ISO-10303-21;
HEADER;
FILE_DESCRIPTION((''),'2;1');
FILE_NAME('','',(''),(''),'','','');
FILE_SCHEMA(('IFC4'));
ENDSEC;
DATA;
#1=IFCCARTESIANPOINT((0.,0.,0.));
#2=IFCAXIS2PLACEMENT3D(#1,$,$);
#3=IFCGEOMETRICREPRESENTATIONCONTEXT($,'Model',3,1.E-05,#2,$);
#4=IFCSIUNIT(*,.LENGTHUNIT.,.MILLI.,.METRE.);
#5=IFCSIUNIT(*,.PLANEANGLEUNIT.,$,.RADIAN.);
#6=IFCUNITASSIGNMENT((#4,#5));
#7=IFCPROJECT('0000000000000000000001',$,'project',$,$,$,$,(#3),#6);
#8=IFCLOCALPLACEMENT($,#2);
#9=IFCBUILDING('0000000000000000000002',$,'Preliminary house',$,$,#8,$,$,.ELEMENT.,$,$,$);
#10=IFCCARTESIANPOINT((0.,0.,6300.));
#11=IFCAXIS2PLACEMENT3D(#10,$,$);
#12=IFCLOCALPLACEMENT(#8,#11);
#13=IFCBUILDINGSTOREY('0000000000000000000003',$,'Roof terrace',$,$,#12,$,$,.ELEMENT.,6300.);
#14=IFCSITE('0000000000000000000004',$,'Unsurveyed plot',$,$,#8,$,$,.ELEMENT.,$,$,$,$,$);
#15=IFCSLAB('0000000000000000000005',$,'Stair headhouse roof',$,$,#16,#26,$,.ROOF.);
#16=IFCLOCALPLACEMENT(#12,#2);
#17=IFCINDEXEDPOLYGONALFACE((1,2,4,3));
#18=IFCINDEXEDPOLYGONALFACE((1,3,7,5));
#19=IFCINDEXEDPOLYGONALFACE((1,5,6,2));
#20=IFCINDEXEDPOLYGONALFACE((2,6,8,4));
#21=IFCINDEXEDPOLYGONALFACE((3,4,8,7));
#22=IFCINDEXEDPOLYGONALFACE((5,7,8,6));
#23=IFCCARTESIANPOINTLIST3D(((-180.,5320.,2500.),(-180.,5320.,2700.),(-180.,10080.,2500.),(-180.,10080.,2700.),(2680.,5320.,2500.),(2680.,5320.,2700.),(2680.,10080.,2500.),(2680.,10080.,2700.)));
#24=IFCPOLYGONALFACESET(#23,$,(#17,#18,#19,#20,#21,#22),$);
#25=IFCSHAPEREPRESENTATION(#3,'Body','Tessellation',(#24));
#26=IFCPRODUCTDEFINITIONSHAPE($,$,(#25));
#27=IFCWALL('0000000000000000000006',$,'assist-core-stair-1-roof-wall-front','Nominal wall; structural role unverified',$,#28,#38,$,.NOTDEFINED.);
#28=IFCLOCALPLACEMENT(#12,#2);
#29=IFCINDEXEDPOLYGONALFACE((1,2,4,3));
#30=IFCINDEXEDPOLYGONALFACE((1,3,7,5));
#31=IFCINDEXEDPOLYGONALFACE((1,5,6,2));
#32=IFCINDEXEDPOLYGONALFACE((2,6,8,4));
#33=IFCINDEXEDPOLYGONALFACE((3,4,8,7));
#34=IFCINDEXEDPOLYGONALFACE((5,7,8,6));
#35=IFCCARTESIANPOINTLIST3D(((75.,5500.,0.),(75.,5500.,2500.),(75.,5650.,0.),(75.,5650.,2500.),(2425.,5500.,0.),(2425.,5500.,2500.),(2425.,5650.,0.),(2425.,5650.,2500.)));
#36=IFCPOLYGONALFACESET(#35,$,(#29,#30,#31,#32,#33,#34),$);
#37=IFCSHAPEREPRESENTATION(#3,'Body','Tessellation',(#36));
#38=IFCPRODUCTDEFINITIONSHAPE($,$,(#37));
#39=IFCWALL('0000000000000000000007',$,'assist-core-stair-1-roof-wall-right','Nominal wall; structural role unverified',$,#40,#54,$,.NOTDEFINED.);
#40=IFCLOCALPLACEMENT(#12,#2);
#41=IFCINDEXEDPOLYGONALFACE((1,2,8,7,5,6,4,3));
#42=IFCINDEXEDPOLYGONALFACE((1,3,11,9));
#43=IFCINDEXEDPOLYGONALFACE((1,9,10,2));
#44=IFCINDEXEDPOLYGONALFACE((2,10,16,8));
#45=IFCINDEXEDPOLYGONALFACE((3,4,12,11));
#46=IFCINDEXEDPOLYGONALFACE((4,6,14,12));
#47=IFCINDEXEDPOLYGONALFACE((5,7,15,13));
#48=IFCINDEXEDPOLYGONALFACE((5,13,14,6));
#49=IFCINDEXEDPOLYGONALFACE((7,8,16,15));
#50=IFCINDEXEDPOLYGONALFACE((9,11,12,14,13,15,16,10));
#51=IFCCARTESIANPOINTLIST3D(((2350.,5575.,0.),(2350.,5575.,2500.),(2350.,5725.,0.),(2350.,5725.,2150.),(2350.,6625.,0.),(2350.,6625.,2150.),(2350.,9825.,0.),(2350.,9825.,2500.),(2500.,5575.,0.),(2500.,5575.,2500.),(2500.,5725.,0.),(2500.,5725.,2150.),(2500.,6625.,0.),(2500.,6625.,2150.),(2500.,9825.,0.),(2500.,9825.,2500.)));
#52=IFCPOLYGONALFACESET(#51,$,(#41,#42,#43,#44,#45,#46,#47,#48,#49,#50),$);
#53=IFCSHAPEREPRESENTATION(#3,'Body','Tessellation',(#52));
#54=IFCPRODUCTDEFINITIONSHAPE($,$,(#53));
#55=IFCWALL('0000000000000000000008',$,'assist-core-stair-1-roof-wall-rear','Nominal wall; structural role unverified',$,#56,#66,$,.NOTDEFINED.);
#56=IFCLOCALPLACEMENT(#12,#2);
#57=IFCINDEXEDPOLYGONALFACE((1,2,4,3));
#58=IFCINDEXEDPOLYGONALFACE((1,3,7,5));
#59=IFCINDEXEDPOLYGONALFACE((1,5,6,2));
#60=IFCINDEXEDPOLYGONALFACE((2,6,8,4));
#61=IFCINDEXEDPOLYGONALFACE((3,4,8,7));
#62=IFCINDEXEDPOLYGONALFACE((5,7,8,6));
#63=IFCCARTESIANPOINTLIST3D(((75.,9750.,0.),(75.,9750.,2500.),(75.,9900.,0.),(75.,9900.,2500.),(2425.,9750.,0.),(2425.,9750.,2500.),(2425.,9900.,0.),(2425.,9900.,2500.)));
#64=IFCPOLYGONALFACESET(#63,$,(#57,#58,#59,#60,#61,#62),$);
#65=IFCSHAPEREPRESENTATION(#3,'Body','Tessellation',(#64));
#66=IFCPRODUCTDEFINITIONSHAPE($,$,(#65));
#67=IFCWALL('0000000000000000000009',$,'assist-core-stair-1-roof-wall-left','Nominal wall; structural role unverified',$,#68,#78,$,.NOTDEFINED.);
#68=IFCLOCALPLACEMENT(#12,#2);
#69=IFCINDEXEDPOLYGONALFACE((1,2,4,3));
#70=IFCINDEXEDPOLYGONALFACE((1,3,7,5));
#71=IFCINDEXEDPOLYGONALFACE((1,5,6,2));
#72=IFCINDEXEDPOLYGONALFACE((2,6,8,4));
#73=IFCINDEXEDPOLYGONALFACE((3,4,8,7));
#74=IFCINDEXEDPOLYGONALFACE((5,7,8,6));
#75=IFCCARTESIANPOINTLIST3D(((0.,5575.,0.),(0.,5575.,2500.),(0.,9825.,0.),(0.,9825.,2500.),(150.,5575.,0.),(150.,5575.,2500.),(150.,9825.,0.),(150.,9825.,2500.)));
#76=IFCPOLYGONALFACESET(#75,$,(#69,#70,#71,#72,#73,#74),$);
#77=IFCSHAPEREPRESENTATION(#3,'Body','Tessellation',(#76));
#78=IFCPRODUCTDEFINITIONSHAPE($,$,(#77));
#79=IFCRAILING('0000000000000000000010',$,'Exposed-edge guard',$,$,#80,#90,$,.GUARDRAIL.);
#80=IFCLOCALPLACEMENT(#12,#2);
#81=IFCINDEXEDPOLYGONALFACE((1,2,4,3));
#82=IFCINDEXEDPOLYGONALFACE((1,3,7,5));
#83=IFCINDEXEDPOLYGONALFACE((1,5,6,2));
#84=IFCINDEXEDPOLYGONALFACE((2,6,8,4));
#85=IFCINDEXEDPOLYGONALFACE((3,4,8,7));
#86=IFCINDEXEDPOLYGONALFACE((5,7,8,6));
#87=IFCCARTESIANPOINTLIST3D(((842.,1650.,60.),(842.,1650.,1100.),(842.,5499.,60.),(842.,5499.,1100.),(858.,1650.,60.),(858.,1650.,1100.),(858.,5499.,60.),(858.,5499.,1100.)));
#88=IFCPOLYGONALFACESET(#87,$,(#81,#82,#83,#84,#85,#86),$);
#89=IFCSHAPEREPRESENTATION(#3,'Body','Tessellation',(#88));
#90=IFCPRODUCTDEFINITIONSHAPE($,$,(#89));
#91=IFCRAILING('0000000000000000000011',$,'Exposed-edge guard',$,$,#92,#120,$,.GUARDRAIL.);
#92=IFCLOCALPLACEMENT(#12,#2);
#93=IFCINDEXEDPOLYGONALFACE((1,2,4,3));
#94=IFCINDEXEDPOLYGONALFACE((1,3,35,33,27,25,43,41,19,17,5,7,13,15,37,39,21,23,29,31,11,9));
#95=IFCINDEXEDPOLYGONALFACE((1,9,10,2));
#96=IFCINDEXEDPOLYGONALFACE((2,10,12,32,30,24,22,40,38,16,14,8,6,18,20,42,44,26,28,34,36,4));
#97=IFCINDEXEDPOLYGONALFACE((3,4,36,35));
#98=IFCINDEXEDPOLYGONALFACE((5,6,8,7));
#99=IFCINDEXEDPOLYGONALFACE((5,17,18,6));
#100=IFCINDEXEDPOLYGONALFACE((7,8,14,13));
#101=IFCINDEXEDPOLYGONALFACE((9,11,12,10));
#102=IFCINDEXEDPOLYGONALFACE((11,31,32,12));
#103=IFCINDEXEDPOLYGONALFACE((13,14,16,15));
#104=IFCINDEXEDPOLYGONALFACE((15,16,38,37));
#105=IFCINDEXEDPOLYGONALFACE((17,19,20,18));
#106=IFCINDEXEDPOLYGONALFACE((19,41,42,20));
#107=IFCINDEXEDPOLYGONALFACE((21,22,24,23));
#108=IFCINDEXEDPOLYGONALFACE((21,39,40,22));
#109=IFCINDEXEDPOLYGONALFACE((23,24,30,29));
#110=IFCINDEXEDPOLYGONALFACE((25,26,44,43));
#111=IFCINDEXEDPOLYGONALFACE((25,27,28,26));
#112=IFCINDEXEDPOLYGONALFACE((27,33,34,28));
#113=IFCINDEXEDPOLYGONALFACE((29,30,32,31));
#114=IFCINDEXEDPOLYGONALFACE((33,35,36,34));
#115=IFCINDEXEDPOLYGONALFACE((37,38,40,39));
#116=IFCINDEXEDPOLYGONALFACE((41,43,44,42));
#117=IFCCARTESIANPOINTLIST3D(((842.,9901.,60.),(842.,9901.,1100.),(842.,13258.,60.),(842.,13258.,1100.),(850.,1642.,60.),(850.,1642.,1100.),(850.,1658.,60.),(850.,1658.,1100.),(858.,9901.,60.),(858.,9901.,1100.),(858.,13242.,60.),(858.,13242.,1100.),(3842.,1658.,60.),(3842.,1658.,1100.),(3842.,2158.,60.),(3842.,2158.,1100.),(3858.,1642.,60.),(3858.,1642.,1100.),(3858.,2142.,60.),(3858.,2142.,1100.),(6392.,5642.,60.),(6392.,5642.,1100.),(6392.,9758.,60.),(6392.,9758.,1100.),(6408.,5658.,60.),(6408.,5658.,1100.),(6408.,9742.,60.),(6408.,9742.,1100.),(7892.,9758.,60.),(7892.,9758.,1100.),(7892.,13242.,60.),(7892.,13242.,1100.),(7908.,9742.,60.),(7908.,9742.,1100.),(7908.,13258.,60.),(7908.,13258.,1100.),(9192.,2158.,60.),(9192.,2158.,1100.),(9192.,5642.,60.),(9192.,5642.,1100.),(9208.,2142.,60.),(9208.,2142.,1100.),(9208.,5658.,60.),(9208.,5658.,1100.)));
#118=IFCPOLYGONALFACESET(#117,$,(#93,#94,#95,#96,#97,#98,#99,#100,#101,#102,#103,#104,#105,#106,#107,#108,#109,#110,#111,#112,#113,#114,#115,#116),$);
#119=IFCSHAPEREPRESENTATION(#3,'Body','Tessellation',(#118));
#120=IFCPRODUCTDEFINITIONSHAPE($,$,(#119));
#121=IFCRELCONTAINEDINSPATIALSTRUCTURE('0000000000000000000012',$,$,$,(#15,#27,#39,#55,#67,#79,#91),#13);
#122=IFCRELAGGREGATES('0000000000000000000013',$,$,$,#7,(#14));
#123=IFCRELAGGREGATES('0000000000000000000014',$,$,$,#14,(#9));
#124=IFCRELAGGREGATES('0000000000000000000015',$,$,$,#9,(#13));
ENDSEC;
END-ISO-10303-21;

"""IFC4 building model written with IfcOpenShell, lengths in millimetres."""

from ifc_helpers import new_model, si_unit, frame, origin, place, context, project, spatial, polyline, outline, extrude, element, save


model = new_model("IFC4")

# Units and contexts
model_context = context("Model", 3, precision=1e-05, world=origin())
ifc_project = project(units=[si_unit("LENGTHUNIT", "METRE", prefix="MILLI"), si_unit("PLANEANGLEUNIT", "RADIAN")], contexts=[model_context])

# Site, building, storey
placement_1 = place(None, origin())
site = spatial("IfcSite", under=ifc_project, at=placement_1, Name="Unsurveyed plot", CompositionType="ELEMENT")
building = spatial("IfcBuilding", under=site, at=placement_1, Name="Preliminary house", CompositionType="ELEMENT")
placement_2 = place(placement_1, frame((0.0, 0.0, 6300.0)))
storey = spatial("IfcBuildingStorey", under=building, at=placement_2, Name="Roof terrace", CompositionType="ELEMENT", Elevation=6300.0)

# Slab
element("IfcSlab", 1, at=placement_2, inside=storey, Name="Stair headhouse roof", PredefinedType="ROOF", context=model_context, shape_type="SweptSolid", body=[
    extrude(outline(polyline([(2680.0, 5320.0), (-180.0, 5320.0), (-180.0, 10080.0), (2680.0, 10080.0), (2680.0, 5320.0)])), frame((0.0, 0.0, 2500.0)), (0.0, 0.0, 1.0), 200.0),
])

# Wall
element("IfcWall", 2, at=placement_2, inside=storey, Name="assist-core-stair-1-roof-wall-front", Description="Nominal wall; structural role unverified", PredefinedType="NOTDEFINED", context=model_context, shape_type="SweptSolid", body=[
    extrude(outline(polyline([(2425.0, 5650.0), (2425.0, 5500.0), (75.0, 5500.0), (75.0, 5650.0), (2425.0, 5650.0)])), origin(), (0.0, 0.0, 1.0), 2500.0),
])

# Wall, opening
wall_1 = element("IfcWall", 3, at=placement_2, inside=storey, Name="assist-core-stair-1-roof-wall-right", Description="Nominal wall; structural role unverified", PredefinedType="NOTDEFINED", context=model_context, shape_type="SweptSolid", body=[
    extrude(outline(polyline([(2350.0, 9825.0), (2500.0, 9825.0), (2500.0, 5575.0), (2350.0, 5575.0), (2350.0, 9825.0)])), origin(), (0.0, 0.0, 1.0), 2500.0),
])
element("IfcOpeningElement", 4, at=placement_2, cuts=wall_1, PredefinedType="OPENING", context=model_context, shape_type="SweptSolid", body=[
    extrude(outline(polyline([(2875.0, 5725.0), (2875.0, 6625.0), (1975.0, 6625.0), (1975.0, 5725.0), (2875.0, 5725.0)])), origin(), (0.0, 0.0, 1.0), 2150.0),
])

# Walls
element("IfcWall", 5, at=placement_2, inside=storey, Name="assist-core-stair-1-roof-wall-rear", Description="Nominal wall; structural role unverified", PredefinedType="NOTDEFINED", context=model_context, shape_type="SweptSolid", body=[
    extrude(outline(polyline([(2425.0, 9900.0), (2425.0, 9750.0), (75.0, 9750.0), (75.0, 9900.0), (2425.0, 9900.0)])), origin(), (0.0, 0.0, 1.0), 2500.0),
])
element("IfcWall", 6, at=placement_2, inside=storey, Name="assist-core-stair-1-roof-wall-left", Description="Nominal wall; structural role unverified", PredefinedType="NOTDEFINED", context=model_context, shape_type="SweptSolid", body=[
    extrude(outline(polyline([(0.0, 9825.0), (150.0, 9825.0), (150.0, 5575.0), (0.0, 5575.0), (0.0, 9825.0)])), origin(), (0.0, 0.0, 1.0), 2500.0),
])

# Railings
element("IfcRailing", 7, at=placement_2, inside=storey, Name="Exposed-edge guard", PredefinedType="GUARDRAIL", context=model_context, shape_type="SweptSolid", body=[
    extrude(outline(polyline([(842.0, 5499.0), (858.0, 5499.0), (858.0, 1650.0), (842.0, 1650.0), (842.0, 5499.0)])), frame((0.0, 0.0, 60.0)), (0.0, 0.0, 1.0), 1040.0),
])
element("IfcRailing", 8, at=placement_2, inside=storey, Name="Exposed-edge guard", PredefinedType="GUARDRAIL", context=model_context, shape_type="SweptSolid", body=[
    extrude(outline(polyline([(842.0, 13258.0), (7908.0, 13258.0), (7908.0, 9742.0), (6408.0, 9742.0), (6408.0, 5658.0), (9208.0, 5658.0), (9208.0, 2142.0), (3858.0, 2142.0), (3858.0, 1642.0), (850.0, 1642.0), (850.0, 1658.0), (3842.0, 1658.0), (3842.0, 2158.0), (9192.0, 2158.0), (9192.0, 5642.0), (6392.0, 5642.0), (6392.0, 9758.0), (7892.0, 9758.0), (7892.0, 13242.0), (858.0, 13242.0), (858.0, 9901.0), (842.0, 9901.0), (842.0, 13258.0)])), frame((0.0, 0.0, 60.0)), (0.0, 0.0, 1.0), 1040.0),
])

save(model, "model.ifc")
